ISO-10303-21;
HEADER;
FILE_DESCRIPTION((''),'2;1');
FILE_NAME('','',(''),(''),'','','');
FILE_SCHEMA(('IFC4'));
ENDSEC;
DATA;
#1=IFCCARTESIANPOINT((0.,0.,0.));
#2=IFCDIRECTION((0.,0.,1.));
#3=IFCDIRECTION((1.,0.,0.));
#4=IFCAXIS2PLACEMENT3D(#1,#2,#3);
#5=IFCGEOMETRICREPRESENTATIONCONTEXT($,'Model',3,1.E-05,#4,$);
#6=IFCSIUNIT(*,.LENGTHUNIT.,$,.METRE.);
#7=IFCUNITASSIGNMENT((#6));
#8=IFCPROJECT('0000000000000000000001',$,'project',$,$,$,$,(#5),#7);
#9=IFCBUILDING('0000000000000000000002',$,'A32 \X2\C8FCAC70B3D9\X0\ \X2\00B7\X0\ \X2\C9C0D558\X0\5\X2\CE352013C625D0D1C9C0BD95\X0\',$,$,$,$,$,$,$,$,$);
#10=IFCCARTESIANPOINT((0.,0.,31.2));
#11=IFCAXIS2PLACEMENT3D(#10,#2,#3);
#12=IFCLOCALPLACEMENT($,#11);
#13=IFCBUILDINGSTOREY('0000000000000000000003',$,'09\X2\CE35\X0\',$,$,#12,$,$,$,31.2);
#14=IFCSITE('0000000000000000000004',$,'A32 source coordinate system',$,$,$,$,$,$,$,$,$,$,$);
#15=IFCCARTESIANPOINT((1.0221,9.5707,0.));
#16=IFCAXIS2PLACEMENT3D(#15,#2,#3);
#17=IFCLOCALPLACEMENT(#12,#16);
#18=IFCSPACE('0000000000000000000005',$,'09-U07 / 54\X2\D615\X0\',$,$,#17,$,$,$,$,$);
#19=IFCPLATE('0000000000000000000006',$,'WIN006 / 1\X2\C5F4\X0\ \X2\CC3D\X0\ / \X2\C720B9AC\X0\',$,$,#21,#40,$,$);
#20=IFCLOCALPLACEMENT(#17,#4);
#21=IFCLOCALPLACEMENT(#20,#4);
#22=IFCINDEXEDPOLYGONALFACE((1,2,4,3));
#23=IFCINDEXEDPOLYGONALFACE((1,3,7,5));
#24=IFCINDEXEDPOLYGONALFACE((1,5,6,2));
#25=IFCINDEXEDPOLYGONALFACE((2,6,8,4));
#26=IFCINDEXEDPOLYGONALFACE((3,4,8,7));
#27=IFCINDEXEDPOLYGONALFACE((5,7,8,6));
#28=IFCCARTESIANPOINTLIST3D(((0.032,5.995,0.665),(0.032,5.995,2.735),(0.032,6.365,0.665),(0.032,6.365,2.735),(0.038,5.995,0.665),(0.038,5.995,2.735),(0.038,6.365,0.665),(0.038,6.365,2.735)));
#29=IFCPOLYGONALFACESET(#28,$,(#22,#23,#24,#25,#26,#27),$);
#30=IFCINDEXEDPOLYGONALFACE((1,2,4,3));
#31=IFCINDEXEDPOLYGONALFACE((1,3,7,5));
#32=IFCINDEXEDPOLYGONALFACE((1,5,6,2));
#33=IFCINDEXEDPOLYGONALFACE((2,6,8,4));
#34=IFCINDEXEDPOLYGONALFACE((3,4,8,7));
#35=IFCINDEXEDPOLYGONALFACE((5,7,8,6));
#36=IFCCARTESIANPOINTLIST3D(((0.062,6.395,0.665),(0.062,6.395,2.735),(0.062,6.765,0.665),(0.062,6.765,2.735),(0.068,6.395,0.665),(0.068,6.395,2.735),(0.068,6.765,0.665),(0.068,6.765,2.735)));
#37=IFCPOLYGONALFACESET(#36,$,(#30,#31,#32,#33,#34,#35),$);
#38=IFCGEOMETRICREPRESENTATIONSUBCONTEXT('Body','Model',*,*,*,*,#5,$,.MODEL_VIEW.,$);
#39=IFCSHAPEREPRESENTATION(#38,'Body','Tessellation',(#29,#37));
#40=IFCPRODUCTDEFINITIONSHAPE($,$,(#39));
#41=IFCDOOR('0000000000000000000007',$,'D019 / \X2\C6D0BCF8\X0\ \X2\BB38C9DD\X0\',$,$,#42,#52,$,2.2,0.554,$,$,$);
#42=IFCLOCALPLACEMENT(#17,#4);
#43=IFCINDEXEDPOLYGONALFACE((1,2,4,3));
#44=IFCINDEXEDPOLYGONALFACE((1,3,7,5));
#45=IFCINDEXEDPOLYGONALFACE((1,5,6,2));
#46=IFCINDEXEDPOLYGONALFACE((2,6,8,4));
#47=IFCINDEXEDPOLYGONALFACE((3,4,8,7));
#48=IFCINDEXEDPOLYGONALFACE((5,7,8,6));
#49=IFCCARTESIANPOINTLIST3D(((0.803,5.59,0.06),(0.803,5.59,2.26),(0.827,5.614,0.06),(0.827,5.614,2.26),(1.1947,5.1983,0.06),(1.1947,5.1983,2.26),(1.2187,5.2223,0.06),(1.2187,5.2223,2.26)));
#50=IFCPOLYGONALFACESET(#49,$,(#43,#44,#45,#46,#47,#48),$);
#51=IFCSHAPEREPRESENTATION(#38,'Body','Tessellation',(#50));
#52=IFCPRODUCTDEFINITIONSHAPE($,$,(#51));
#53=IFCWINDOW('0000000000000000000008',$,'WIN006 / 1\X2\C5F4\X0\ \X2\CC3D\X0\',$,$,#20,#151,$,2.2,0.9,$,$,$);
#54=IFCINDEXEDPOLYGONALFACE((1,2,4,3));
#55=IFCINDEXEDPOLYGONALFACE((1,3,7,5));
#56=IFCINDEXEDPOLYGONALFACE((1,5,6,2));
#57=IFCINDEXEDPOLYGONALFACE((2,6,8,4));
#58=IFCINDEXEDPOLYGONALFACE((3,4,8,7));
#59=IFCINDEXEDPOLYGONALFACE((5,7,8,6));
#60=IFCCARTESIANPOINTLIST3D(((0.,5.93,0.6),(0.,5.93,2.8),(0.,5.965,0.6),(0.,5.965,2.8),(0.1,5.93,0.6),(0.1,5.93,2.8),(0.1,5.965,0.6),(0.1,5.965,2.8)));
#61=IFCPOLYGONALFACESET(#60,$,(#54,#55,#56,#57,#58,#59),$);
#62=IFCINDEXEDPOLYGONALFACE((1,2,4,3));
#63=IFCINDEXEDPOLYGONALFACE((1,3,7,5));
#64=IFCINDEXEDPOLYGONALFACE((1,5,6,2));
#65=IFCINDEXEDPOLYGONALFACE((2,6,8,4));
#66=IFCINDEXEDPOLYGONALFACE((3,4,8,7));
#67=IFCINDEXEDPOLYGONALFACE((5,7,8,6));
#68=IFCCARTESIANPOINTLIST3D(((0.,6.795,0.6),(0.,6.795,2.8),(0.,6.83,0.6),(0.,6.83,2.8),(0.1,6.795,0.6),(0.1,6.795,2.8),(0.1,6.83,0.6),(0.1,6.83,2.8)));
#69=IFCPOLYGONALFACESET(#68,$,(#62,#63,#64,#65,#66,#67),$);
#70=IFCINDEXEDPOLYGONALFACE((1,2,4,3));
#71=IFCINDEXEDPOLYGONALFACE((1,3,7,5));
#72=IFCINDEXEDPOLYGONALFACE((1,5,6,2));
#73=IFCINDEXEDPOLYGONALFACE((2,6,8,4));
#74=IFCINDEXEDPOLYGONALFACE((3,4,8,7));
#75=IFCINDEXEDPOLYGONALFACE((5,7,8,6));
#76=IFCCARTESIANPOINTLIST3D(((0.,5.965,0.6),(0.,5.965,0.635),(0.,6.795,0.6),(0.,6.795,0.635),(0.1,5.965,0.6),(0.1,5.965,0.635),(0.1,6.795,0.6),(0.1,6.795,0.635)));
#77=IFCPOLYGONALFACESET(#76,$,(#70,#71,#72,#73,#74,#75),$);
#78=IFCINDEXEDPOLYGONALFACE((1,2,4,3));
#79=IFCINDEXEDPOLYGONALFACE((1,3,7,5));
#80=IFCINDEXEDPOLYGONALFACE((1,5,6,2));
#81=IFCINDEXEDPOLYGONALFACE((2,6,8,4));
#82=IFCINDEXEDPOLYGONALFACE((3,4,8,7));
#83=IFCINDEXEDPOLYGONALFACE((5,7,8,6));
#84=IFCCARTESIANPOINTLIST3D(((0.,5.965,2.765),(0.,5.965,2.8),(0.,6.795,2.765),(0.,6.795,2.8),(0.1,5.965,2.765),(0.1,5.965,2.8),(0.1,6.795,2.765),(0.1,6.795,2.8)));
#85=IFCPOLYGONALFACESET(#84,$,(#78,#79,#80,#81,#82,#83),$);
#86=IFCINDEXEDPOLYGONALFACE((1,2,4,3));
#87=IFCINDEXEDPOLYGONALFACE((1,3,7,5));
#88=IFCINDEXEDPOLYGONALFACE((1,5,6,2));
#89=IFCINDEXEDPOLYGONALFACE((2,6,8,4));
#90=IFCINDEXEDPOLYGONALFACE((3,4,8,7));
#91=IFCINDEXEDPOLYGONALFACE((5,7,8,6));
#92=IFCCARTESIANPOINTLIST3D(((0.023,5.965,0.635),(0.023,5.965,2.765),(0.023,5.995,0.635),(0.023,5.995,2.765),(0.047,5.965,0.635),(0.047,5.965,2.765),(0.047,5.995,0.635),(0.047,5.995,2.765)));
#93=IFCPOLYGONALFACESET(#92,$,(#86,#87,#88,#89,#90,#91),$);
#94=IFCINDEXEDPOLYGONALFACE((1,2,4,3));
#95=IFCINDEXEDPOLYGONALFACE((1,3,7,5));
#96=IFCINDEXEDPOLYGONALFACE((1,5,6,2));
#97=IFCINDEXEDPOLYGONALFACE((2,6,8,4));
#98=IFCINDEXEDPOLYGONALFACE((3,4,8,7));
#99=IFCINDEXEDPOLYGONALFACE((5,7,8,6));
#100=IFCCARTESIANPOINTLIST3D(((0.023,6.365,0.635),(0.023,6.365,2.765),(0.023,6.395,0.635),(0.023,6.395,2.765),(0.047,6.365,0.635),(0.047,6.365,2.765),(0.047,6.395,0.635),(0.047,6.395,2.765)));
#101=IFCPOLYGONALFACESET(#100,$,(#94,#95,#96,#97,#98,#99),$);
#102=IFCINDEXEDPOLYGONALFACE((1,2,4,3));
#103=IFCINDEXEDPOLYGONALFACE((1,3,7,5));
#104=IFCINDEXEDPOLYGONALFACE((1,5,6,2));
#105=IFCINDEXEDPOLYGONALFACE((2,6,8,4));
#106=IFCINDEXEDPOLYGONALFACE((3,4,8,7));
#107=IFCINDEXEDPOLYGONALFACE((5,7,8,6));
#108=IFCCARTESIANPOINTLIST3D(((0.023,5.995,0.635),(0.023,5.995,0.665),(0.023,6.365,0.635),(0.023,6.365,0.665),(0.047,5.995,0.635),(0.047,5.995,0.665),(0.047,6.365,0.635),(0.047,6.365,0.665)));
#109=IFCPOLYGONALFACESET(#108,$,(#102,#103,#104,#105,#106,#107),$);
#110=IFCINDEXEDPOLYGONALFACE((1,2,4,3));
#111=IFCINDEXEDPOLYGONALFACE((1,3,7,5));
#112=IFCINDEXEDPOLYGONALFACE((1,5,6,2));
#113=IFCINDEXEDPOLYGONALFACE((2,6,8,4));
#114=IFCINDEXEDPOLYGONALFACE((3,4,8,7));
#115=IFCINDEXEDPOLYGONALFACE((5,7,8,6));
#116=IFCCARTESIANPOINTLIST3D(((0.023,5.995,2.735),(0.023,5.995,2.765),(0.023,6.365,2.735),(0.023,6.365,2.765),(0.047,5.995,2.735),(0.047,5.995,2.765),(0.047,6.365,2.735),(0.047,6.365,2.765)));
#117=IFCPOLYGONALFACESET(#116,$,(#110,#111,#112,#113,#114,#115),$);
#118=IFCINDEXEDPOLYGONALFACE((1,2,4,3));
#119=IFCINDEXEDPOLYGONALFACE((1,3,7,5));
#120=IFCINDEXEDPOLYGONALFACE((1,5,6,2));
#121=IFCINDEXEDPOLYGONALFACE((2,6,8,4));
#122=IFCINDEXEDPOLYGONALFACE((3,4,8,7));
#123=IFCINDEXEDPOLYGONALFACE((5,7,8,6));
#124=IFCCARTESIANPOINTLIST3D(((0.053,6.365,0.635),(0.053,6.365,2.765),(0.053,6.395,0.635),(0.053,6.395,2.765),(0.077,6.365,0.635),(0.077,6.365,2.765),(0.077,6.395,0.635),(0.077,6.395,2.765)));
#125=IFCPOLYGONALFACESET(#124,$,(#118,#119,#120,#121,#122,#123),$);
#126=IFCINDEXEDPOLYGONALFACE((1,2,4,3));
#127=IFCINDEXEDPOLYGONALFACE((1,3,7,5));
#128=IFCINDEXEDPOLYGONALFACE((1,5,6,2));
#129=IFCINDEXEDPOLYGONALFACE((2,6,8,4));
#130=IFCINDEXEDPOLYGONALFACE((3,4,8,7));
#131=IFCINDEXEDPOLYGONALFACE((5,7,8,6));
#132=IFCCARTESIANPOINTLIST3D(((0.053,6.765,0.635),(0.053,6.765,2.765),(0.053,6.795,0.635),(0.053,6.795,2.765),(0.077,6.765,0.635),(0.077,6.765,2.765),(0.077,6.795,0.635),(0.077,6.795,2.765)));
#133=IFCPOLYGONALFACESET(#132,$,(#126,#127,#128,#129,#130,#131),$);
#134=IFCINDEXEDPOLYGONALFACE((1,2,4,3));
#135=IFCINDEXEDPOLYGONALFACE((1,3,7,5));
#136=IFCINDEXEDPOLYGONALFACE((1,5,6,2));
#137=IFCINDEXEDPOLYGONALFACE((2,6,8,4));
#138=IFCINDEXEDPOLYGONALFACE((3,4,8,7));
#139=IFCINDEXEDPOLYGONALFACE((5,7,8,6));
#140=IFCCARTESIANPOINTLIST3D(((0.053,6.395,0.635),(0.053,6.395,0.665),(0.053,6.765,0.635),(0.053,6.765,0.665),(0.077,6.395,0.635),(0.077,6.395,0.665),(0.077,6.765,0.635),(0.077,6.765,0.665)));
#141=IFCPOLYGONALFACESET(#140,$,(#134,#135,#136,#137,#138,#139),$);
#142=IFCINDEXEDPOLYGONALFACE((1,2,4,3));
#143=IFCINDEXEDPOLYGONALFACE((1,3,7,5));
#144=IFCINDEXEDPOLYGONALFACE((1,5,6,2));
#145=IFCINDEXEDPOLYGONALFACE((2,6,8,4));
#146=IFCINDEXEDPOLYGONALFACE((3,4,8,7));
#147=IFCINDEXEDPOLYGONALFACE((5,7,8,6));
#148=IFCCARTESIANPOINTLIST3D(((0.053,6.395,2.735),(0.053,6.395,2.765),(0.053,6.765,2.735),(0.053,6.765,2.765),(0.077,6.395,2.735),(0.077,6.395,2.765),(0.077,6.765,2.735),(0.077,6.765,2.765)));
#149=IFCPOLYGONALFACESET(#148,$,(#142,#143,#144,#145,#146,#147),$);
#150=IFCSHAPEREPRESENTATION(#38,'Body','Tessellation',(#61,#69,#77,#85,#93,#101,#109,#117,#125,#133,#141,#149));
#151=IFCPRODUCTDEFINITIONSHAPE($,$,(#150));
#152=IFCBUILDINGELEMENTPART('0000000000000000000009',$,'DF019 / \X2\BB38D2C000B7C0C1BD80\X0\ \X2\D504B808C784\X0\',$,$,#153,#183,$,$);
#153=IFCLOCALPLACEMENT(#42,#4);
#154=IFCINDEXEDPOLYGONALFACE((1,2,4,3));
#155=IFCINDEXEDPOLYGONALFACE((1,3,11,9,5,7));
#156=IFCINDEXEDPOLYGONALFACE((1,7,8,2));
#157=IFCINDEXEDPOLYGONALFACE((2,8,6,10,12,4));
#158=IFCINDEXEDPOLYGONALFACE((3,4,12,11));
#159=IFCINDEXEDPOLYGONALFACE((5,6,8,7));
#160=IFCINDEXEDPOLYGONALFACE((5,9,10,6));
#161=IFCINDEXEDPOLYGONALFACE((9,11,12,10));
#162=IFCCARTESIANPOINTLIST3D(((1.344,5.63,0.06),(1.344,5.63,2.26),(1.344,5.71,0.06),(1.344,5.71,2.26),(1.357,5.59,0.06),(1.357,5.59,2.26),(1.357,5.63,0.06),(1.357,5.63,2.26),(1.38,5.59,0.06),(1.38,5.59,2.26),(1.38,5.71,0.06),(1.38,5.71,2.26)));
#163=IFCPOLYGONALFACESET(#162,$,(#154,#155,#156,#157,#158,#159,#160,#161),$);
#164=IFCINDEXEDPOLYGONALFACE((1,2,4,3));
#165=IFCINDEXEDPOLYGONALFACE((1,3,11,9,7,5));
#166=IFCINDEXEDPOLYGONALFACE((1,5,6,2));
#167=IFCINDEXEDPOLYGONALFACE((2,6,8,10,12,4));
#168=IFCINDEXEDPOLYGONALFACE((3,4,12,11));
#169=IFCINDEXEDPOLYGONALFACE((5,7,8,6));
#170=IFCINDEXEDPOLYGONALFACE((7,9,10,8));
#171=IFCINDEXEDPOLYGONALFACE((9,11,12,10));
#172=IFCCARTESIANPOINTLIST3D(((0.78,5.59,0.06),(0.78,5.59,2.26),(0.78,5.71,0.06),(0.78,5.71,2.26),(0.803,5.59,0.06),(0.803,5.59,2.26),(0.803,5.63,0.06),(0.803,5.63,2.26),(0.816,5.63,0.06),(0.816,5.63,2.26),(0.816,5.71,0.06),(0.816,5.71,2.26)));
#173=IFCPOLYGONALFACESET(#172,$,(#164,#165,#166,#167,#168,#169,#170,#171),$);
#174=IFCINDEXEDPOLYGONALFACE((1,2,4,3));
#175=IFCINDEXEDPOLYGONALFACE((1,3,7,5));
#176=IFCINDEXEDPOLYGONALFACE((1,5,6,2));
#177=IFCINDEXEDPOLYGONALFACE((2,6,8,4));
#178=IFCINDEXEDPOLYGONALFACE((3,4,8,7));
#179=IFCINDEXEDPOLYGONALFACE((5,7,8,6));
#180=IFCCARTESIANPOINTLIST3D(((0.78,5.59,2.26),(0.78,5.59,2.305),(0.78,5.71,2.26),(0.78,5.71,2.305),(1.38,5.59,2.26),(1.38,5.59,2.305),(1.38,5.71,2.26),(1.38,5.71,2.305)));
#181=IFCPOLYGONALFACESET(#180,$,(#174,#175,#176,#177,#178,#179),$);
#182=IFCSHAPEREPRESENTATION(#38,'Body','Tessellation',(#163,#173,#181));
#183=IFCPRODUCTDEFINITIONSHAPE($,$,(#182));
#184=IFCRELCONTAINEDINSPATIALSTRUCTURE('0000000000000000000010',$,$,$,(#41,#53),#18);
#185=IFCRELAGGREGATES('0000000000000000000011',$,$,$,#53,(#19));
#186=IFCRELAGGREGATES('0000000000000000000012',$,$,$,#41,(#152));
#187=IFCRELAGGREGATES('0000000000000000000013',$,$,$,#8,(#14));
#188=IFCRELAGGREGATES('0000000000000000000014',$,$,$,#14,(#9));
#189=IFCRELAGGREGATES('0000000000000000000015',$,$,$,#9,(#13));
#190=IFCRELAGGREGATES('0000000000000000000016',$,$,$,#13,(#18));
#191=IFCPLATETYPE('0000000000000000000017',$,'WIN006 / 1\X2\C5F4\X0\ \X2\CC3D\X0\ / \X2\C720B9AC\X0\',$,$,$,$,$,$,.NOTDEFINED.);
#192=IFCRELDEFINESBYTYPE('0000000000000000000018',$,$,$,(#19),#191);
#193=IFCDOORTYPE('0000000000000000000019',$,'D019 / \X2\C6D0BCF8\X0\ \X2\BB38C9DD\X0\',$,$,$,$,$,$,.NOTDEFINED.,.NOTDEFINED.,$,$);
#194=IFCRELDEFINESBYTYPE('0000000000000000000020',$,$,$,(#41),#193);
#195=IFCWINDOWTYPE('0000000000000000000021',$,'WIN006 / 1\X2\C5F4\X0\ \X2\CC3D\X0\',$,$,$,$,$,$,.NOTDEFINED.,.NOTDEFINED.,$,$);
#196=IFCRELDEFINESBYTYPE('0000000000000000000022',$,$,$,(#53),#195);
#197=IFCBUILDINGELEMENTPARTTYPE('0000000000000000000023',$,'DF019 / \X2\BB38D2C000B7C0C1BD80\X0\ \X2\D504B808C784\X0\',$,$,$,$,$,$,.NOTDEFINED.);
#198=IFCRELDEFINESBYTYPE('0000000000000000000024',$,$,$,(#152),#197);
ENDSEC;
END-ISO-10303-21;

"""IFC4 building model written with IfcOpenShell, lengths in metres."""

from ifc_helpers import new_model, si_unit, frame, origin, origin_with_axes, place, context, subcontext, project, spatial, polyline, outline, extrude, source, transform, mapped, type_object, type_shapes, element, aggregate, save


model = new_model("IFC4")

# Units and contexts
model_context = context("Model", 3, precision=1e-05, world=origin_with_axes())
body_context = subcontext(model_context, "Body", "Model", "MODEL_VIEW")
ifc_project = project(units=[si_unit("LENGTHUNIT", "METRE")], contexts=[model_context])

# Plate
storey_placement = place(None, frame((0.0, 0.0, 31.2), z_axis=(0.0, 0.0, 1.0), x_axis=(1.0, 0.0, 0.0)))
space_placement = place(storey_placement, frame((1.0221, 9.5707, 0.0), z_axis=(0.0, 0.0, 1.0), x_axis=(1.0, 0.0, 0.0)))
plate_type_1 = type_object("IfcPlateType", Name="WIN006 / 1열 창 / 유리", PredefinedType="NOTDEFINED")
shared_shape_1 = source(origin(), body_context, "Body", "SweptSolid", [
    extrude(outline(polyline([(0.032, 5.995), (0.032, 6.365), (0.038, 6.365), (0.038, 5.995), (0.032, 5.995)])), frame((0.0, 0.0, 0.665)), (0.0, 0.0, 1.0), 2.07),
    extrude(outline(polyline([(0.062, 6.395), (0.062, 6.765), (0.068, 6.765), (0.068, 6.395), (0.062, 6.395)])), frame((0.0, 0.0, 0.665)), (0.0, 0.0, 1.0), 2.07),
])
type_shapes(plate_type_1, [shared_shape_1])
window_1_placement = place(space_placement, origin_with_axes())
plate_1_placement = place(window_1_placement, origin_with_axes())
plate_1 = element("IfcPlate", 1, at=plate_1_placement, type_object=plate_type_1, Name="WIN006 / 1열 창 / 유리", context=body_context, shape_type="MappedRepresentation", body=[
    mapped(shared_shape_1, transform((0.0, 0.0, 0.0), scale=1.0)),
])

# Site, building, storey, space
site = spatial("IfcSite", under=ifc_project, Name="A32 source coordinate system")
building = spatial("IfcBuilding", under=site, Name="A32 주거동 · 지하5층–옥탑지붕")
storey = spatial("IfcBuildingStorey", under=building, at=storey_placement, Name="09층", Elevation=31.2)
space = spatial("IfcSpace", under=storey, at=space_placement, Name="09-U07 / 54형")

# Door
door_type_1 = type_object("IfcDoorType", Name="D019 / 원본 문짝", OperationType="NOTDEFINED", PredefinedType="NOTDEFINED")
shared_shape_2 = source(origin(), body_context, "Body", "SweptSolid", [
    extrude(outline(polyline([(1.2187, 5.2223), (1.1947, 5.1983), (0.803, 5.59), (0.827, 5.614), (1.2187, 5.2223)])), frame((0.0, 0.0, 0.06)), (0.0, 0.0, 1.0), 2.2),
])
type_shapes(door_type_1, [shared_shape_2])
door_1_placement = place(space_placement, origin_with_axes())
door_1 = element("IfcDoor", 2, at=door_1_placement, inside=space, type_object=door_type_1, Name="D019 / 원본 문짝", OverallHeight=2.2, OverallWidth=0.554, context=body_context, shape_type="MappedRepresentation", body=[
    mapped(shared_shape_2, transform((0.0, 0.0, 0.0), scale=1.0)),
])

# Window
window_type_1 = type_object("IfcWindowType", Name="WIN006 / 1열 창", PartitioningType="NOTDEFINED", PredefinedType="NOTDEFINED")
shared_shape_3 = source(origin(), body_context, "Body", "SweptSolid", [
    extrude(outline(polyline([(0.0, 5.93), (0.0, 5.965), (0.1, 5.965), (0.1, 5.93), (0.0, 5.93)])), frame((0.0, 0.0, 0.6)), (0.0, 0.0, 1.0), 2.2),
    extrude(outline(polyline([(0.0, 6.795), (0.0, 6.83), (0.1, 6.83), (0.1, 6.795), (0.0, 6.795)])), frame((0.0, 0.0, 0.6)), (0.0, 0.0, 1.0), 2.2),
    extrude(outline(polyline([(0.0, 5.965), (0.0, 6.795), (0.1, 6.795), (0.1, 5.965), (0.0, 5.965)])), frame((0.0, 0.0, 0.6)), (0.0, 0.0, 1.0), 0.035),
    extrude(outline(polyline([(0.0, 5.965), (0.0, 6.795), (0.1, 6.795), (0.1, 5.965), (0.0, 5.965)])), frame((0.0, 0.0, 2.765)), (0.0, 0.0, 1.0), 0.035),
    extrude(outline(polyline([(0.023, 5.965), (0.023, 5.995), (0.047, 5.995), (0.047, 5.965), (0.023, 5.965)])), frame((0.0, 0.0, 0.635)), (0.0, 0.0, 1.0), 2.13),
    extrude(outline(polyline([(0.023, 6.365), (0.023, 6.395), (0.047, 6.395), (0.047, 6.365), (0.023, 6.365)])), frame((0.0, 0.0, 0.635)), (0.0, 0.0, 1.0), 2.13),
    extrude(outline(polyline([(0.023, 5.995), (0.023, 6.365), (0.047, 6.365), (0.047, 5.995), (0.023, 5.995)])), frame((0.0, 0.0, 0.635)), (0.0, 0.0, 1.0), 0.03),
    extrude(outline(polyline([(0.023, 5.995), (0.023, 6.365), (0.047, 6.365), (0.047, 5.995), (0.023, 5.995)])), frame((0.0, 0.0, 2.735)), (0.0, 0.0, 1.0), 0.03),
    extrude(outline(polyline([(0.053, 6.365), (0.053, 6.395), (0.077, 6.395), (0.077, 6.365), (0.053, 6.365)])), frame((0.0, 0.0, 0.635)), (0.0, 0.0, 1.0), 2.13),
    extrude(outline(polyline([(0.053, 6.765), (0.053, 6.795), (0.077, 6.795), (0.077, 6.765), (0.053, 6.765)])), frame((0.0, 0.0, 0.635)), (0.0, 0.0, 1.0), 2.13),
    extrude(outline(polyline([(0.053, 6.395), (0.053, 6.765), (0.077, 6.765), (0.077, 6.395), (0.053, 6.395)])), frame((0.0, 0.0, 0.635)), (0.0, 0.0, 1.0), 0.03),
    extrude(outline(polyline([(0.053, 6.395), (0.053, 6.765), (0.077, 6.765), (0.077, 6.395), (0.053, 6.395)])), frame((0.0, 0.0, 2.735)), (0.0, 0.0, 1.0), 0.03),
])
type_shapes(window_type_1, [shared_shape_3])
window_1 = element("IfcWindow", 3, at=window_1_placement, inside=space, type_object=window_type_1, Name="WIN006 / 1열 창", OverallHeight=2.2, OverallWidth=0.9, context=body_context, shape_type="MappedRepresentation", body=[
    mapped(shared_shape_3, transform((0.0, 0.0, 0.0), scale=1.0)),
])
aggregate(window_1, [plate_1])

# Building element part
building_element_part_type_1 = type_object("IfcBuildingElementPartType", Name="DF019 / 문틀·상부 프레임", PredefinedType="NOTDEFINED")
shared_shape_4 = source(origin(), body_context, "Body", "SweptSolid", [
    extrude(outline(polyline([(1.38, 5.59), (1.357, 5.59), (1.357, 5.63), (1.344, 5.63), (1.344, 5.71), (1.38, 5.71), (1.38, 5.59)])), frame((0.0, 0.0, 0.06)), (0.0, 0.0, 1.0), 2.2),
    extrude(outline(polyline([(0.816, 5.71), (0.816, 5.63), (0.803, 5.63), (0.803, 5.59), (0.78, 5.59), (0.78, 5.71), (0.816, 5.71)])), frame((0.0, 0.0, 0.06)), (0.0, 0.0, 1.0), 2.2),
    extrude(outline(polyline([(0.78, 5.59), (0.78, 5.71), (1.38, 5.71), (1.38, 5.59), (0.78, 5.59)])), frame((0.0, 0.0, 2.26)), (0.0, 0.0, 1.0), 0.045),
])
type_shapes(building_element_part_type_1, [shared_shape_4])
building_element_part_1_placement = place(door_1_placement, origin_with_axes())
building_element_part_1 = element("IfcBuildingElementPart", 4, at=building_element_part_1_placement, type_object=building_element_part_type_1, Name="DF019 / 문틀·상부 프레임", context=body_context, shape_type="MappedRepresentation", body=[
    mapped(shared_shape_4, transform((0.0, 0.0, 0.0), scale=1.0)),
])
aggregate(door_1, [building_element_part_1])

save(model, "model.ifc")
